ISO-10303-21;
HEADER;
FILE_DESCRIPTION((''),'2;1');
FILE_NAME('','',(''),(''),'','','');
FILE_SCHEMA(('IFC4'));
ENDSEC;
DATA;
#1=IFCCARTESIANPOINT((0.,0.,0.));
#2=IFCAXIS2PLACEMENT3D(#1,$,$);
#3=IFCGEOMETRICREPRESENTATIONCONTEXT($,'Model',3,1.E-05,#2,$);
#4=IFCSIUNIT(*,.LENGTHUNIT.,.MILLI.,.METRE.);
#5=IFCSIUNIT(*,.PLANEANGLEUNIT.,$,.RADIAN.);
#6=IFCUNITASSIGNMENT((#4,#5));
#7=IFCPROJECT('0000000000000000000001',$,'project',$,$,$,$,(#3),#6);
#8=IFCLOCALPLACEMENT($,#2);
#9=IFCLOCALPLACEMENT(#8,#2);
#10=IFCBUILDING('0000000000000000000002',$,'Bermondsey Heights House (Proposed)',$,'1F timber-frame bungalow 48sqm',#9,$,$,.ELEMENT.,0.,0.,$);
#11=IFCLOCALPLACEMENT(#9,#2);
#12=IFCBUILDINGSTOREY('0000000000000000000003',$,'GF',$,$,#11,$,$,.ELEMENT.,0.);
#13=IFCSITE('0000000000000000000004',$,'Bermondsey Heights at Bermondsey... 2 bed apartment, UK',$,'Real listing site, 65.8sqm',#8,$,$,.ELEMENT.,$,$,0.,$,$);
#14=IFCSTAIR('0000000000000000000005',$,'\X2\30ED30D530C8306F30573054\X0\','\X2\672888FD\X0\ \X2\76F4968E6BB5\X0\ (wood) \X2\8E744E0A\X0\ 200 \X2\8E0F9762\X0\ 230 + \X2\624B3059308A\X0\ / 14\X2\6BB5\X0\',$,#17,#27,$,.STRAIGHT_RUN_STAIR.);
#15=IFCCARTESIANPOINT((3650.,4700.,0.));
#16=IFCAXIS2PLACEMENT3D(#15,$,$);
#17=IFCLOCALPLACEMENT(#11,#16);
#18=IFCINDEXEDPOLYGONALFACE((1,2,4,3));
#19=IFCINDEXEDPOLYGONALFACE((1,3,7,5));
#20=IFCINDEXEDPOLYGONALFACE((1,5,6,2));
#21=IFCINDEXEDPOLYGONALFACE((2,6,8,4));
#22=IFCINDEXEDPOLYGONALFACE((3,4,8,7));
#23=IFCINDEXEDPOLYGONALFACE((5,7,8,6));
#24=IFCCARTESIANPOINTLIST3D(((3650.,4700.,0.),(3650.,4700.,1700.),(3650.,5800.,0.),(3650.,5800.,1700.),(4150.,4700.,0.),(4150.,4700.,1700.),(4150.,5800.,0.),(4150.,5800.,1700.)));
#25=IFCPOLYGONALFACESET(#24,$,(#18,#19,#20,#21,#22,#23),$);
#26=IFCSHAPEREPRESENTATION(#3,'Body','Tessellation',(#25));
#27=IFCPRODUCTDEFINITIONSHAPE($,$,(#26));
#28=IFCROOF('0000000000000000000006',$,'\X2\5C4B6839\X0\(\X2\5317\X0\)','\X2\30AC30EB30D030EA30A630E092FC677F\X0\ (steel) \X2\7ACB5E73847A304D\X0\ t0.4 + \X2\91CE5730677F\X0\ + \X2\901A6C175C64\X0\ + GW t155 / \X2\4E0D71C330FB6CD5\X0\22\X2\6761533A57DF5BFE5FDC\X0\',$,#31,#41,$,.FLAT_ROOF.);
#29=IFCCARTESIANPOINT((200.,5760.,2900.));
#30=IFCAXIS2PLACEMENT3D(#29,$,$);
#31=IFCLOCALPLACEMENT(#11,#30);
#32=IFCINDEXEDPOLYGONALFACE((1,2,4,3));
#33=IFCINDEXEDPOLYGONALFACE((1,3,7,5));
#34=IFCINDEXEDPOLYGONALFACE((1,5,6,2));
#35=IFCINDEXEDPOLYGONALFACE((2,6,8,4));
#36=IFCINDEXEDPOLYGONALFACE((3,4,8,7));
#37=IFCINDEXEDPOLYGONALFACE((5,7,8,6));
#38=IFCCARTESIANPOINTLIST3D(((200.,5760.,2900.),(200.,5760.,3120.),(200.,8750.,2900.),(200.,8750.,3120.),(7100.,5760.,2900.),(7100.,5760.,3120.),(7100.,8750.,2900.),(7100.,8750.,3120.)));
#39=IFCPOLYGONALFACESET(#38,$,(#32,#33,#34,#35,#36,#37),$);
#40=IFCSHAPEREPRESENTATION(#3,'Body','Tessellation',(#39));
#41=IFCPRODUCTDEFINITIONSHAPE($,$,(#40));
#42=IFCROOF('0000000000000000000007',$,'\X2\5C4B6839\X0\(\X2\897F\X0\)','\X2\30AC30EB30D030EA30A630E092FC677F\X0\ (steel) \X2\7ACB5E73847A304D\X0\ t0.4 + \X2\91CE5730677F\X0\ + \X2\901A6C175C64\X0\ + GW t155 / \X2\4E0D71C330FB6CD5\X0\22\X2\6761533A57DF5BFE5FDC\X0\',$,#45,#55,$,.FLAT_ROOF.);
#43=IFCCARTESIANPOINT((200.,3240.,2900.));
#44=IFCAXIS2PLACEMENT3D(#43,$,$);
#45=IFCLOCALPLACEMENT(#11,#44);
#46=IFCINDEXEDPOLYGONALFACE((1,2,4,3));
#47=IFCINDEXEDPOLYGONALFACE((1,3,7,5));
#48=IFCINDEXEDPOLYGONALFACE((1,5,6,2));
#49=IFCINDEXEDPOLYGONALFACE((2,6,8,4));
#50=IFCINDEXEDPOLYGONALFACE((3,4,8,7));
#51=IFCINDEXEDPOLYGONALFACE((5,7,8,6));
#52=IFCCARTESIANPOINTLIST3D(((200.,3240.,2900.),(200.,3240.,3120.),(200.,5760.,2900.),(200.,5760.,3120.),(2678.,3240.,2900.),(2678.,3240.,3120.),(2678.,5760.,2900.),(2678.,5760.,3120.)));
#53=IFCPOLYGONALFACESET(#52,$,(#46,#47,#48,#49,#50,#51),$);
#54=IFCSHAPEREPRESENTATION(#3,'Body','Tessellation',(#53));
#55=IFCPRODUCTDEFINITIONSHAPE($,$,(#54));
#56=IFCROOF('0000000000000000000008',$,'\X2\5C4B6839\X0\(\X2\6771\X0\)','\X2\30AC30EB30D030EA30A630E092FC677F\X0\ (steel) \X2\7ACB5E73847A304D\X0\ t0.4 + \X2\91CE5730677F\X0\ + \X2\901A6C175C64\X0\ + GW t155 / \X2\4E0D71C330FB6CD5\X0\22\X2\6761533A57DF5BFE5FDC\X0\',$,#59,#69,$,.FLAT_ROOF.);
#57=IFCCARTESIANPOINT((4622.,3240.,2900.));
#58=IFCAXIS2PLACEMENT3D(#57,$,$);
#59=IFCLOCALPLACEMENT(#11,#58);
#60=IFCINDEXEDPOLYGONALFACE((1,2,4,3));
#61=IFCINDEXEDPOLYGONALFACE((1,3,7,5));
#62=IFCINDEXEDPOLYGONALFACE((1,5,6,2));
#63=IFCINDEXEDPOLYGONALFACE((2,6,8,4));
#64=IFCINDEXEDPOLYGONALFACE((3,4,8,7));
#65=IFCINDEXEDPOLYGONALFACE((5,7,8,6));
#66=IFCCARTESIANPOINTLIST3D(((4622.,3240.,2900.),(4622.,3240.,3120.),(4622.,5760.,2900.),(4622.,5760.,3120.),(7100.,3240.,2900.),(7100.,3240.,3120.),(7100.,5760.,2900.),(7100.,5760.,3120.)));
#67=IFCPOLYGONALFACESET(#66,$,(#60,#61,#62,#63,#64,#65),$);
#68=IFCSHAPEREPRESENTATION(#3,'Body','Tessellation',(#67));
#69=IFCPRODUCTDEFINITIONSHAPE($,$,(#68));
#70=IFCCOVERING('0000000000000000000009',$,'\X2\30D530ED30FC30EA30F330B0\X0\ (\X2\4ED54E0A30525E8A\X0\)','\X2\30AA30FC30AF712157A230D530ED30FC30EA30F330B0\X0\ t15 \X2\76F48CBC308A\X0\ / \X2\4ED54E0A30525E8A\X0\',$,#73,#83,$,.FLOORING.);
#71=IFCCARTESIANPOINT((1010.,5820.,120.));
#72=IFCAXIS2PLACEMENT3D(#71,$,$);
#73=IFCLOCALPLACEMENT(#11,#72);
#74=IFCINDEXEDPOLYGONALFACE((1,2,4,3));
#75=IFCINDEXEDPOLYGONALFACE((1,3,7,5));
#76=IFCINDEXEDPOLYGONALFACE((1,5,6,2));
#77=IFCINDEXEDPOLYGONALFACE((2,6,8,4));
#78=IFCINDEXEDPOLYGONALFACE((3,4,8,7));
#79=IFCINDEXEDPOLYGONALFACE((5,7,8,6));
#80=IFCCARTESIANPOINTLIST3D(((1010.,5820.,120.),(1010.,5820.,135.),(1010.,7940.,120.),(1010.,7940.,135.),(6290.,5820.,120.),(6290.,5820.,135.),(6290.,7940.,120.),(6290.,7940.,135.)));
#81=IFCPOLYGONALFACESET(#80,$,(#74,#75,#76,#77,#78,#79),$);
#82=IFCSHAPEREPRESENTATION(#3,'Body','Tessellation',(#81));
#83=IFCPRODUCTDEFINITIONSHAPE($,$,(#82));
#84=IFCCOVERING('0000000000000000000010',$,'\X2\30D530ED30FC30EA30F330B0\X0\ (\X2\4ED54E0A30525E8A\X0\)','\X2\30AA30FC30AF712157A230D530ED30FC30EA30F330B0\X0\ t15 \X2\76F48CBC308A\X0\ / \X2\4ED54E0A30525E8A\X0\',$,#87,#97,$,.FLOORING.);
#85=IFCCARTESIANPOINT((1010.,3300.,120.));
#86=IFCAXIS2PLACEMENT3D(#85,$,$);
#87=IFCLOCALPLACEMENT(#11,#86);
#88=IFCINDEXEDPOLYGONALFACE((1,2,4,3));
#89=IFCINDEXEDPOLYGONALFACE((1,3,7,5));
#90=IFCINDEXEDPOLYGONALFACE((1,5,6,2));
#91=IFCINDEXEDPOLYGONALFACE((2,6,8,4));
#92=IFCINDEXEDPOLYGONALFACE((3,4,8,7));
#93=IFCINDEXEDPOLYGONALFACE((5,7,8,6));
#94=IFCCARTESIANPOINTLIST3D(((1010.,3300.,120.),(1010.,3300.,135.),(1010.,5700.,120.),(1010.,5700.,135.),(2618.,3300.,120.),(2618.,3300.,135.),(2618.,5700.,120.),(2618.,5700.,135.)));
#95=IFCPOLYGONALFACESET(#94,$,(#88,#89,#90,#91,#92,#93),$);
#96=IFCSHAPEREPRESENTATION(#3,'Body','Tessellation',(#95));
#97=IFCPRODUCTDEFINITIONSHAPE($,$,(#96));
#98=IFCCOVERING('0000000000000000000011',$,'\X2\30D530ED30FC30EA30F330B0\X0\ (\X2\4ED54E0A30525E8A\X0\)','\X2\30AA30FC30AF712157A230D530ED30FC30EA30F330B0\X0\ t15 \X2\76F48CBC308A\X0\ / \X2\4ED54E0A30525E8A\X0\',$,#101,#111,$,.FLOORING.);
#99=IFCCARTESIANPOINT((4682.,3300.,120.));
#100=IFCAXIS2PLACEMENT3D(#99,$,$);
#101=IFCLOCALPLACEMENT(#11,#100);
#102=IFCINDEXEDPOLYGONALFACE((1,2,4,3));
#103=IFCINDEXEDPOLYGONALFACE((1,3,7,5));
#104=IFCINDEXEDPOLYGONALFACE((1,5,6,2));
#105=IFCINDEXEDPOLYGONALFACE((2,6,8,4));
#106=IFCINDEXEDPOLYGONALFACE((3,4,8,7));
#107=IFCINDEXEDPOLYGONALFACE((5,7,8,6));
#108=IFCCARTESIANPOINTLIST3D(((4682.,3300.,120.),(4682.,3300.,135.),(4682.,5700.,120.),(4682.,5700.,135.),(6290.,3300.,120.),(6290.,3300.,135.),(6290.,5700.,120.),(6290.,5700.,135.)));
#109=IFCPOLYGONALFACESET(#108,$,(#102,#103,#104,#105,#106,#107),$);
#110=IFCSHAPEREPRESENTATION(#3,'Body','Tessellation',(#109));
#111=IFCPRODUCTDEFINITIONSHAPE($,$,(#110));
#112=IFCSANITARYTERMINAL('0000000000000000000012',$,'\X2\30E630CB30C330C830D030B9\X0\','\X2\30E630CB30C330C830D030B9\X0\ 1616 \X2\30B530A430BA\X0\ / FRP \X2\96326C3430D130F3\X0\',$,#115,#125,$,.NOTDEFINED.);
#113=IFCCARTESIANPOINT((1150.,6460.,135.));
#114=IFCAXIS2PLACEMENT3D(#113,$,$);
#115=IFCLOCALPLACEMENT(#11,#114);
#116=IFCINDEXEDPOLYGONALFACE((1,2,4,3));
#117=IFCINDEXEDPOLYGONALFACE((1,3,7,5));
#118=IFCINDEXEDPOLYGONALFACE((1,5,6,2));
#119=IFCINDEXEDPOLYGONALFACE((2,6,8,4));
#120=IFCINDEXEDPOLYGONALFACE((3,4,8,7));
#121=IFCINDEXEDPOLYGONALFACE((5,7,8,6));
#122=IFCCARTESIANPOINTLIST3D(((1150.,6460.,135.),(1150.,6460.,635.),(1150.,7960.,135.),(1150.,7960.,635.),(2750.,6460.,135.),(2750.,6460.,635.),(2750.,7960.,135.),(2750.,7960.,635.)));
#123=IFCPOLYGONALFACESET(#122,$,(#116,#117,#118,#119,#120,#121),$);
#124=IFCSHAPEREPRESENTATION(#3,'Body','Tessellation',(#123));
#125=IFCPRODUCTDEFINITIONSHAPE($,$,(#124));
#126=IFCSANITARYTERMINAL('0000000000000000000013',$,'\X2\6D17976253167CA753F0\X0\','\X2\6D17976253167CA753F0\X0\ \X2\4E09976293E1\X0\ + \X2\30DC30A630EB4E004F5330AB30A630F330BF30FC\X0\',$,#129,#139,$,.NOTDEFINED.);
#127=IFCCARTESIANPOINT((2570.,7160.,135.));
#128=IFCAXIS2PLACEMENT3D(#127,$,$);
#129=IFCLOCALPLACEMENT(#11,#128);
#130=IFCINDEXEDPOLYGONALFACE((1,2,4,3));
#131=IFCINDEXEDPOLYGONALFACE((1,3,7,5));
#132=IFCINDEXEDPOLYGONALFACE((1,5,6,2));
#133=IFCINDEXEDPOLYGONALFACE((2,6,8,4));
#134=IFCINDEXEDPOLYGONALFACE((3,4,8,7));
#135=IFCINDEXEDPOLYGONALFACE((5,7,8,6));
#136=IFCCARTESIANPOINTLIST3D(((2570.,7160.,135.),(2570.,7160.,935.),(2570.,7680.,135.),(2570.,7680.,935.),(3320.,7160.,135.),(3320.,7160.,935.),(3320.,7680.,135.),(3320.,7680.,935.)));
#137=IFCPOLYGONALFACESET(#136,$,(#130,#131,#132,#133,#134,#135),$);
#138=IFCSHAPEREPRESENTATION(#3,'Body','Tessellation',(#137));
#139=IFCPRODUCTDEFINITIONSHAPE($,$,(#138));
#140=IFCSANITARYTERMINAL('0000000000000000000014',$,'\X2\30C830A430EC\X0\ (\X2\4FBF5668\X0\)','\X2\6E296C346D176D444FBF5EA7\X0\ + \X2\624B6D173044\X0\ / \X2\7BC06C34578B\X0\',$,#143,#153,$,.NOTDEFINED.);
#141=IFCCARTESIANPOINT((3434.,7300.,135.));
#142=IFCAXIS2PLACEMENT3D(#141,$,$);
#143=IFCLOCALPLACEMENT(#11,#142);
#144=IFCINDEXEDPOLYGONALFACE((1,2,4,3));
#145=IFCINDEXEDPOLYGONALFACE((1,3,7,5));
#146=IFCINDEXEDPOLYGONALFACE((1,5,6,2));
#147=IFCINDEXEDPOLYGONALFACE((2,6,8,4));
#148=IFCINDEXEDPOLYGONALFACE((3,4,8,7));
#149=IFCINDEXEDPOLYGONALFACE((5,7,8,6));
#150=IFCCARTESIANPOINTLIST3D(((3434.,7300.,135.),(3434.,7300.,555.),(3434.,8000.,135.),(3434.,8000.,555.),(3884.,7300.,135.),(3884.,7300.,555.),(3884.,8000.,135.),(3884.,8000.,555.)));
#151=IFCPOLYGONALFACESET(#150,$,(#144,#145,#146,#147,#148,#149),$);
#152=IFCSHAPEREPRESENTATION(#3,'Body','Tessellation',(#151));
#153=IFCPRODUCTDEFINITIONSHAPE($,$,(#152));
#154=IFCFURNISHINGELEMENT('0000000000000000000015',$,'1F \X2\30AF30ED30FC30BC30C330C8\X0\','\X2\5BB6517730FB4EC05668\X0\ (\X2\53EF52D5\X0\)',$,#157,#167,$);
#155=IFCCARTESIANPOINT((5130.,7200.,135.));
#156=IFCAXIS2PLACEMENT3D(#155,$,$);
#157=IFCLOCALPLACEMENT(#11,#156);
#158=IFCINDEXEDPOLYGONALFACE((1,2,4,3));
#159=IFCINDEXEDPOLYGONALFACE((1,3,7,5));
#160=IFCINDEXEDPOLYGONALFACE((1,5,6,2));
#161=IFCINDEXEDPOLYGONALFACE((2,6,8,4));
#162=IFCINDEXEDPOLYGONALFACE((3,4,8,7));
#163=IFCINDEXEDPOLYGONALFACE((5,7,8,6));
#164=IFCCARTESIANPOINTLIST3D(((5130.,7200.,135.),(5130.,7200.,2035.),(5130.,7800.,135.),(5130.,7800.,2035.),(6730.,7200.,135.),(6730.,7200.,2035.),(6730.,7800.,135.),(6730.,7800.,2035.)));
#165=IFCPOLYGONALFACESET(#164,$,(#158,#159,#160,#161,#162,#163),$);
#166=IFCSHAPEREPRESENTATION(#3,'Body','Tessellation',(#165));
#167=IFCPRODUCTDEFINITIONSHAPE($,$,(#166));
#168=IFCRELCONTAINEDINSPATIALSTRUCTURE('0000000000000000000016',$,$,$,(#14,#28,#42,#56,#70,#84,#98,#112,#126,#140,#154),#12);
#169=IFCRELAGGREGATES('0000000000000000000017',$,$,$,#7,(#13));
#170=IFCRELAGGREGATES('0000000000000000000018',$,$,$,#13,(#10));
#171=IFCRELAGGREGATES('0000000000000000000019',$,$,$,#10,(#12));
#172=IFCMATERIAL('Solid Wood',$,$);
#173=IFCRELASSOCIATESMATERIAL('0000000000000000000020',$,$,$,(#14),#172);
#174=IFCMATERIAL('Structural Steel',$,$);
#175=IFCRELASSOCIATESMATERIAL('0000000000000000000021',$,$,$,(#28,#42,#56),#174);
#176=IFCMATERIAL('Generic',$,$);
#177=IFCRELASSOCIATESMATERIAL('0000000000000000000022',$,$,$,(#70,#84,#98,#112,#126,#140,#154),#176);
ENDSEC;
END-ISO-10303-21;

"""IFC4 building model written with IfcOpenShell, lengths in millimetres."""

from ifc_helpers import new_model, si_unit, frame, frame_2d, origin, place, context, project, spatial, rectangle, extrude, material, element, save


model = new_model("IFC4")

# Units and contexts
model_context = context("Model", 3, precision=1e-05, world=origin())
ifc_project = project(units=[si_unit("LENGTHUNIT", "METRE", prefix="MILLI"), si_unit("PLANEANGLEUNIT", "RADIAN")], contexts=[model_context])

# Site, building, storey
site_placement = place(None, origin())
site = spatial("IfcSite", under=ifc_project, at=site_placement, Name="Bermondsey Heights at Bermondsey... 2 bed apartment, UK", ObjectType="Real listing site, 65.8sqm", CompositionType="ELEMENT", RefElevation=0.0)
building_placement = place(site_placement, origin())
building = spatial("IfcBuilding", under=site, at=building_placement, Name="Bermondsey Heights House (Proposed)", ObjectType="1F timber-frame bungalow 48sqm", CompositionType="ELEMENT", ElevationOfRefHeight=0.0, ElevationOfTerrain=0.0)
storey_placement = place(building_placement, origin())
storey = spatial("IfcBuildingStorey", under=building, at=storey_placement, Name="GF", CompositionType="ELEMENT", Elevation=0.0)

# Shared definitions
ifc_material_1 = material(Name="Solid Wood")

# Shared definitions
ifc_material_2 = material(Name="Generic")

# Stair
stair_placement = place(storey_placement, frame((3650.0, 4700.0, 0.0)))
element("IfcStair", 1, at=stair_placement, inside=storey, material=ifc_material_1, Name="ロフトはしご", Description="木製 直階段 (wood) 蹴上 200 踏面 230 + 手すり / 14段", PredefinedType="STRAIGHT_RUN_STAIR", context=model_context, shape_type="SweptSolid", body=[
    extrude(rectangle(XDim=500.0, YDim=1100.0, at=frame_2d((250.0, 550.0))), frame((3650.0, 4700.0, 0.0)), (0.0, 0.0, 1.0), 1700.0),
])

# Roofs
ifc_material_3 = material(Name="Structural Steel")
roof_1_placement = place(storey_placement, frame((200.0, 5760.0, 2900.0)))
element("IfcRoof", 2, at=roof_1_placement, inside=storey, material=ifc_material_3, Name="屋根(北)", Description="ガルバリウム鋼板 (steel) 立平葺き t0.4 + 野地板 + 通気層 + GW t155 / 不燃・法22条区域対応", PredefinedType="FLAT_ROOF", context=model_context, shape_type="SweptSolid", body=[
    extrude(rectangle(XDim=6900.0, YDim=2990.0, at=frame_2d((3450.0, 1495.0))), frame((200.0, 5760.0, 2900.0)), (0.0, 0.0, 1.0), 220.0),
])
roof_2_placement = place(storey_placement, frame((200.0, 3240.0, 2900.0)))
element("IfcRoof", 3, at=roof_2_placement, inside=storey, material=ifc_material_3, Name="屋根(西)", Description="ガルバリウム鋼板 (steel) 立平葺き t0.4 + 野地板 + 通気層 + GW t155 / 不燃・法22条区域対応", PredefinedType="FLAT_ROOF", context=model_context, shape_type="SweptSolid", body=[
    extrude(rectangle(XDim=2478.0, YDim=2520.0, at=frame_2d((1239.0, 1260.0))), frame((200.0, 3240.0, 2900.0)), (0.0, 0.0, 1.0), 220.0),
])
roof_3_placement = place(storey_placement, frame((4622.0, 3240.0, 2900.0)))
element("IfcRoof", 4, at=roof_3_placement, inside=storey, material=ifc_material_3, Name="屋根(東)", Description="ガルバリウム鋼板 (steel) 立平葺き t0.4 + 野地板 + 通気層 + GW t155 / 不燃・法22条区域対応", PredefinedType="FLAT_ROOF", context=model_context, shape_type="SweptSolid", body=[
    extrude(rectangle(XDim=2478.0, YDim=2520.0, at=frame_2d((1239.0, 1260.0))), frame((4622.0, 3240.0, 2900.0)), (0.0, 0.0, 1.0), 220.0),
])

# Coverings
covering_1_placement = place(storey_placement, frame((1010.0, 5820.0, 120.0)))
element("IfcCovering", 5, at=covering_1_placement, inside=storey, material=ifc_material_2, Name="フローリング (仕上げ床)", Description="オーク無垢フローリング t15 直貼り / 仕上げ床", PredefinedType="FLOORING", context=model_context, shape_type="SweptSolid", body=[
    extrude(rectangle(XDim=5280.0, YDim=2120.0, at=frame_2d((2640.0, 1060.0))), frame((1010.0, 5820.0, 120.0)), (0.0, 0.0, 1.0), 15.0),
])
covering_2_placement = place(storey_placement, frame((1010.0, 3300.0, 120.0)))
element("IfcCovering", 6, at=covering_2_placement, inside=storey, material=ifc_material_2, Name="フローリング (仕上げ床)", Description="オーク無垢フローリング t15 直貼り / 仕上げ床", PredefinedType="FLOORING", context=model_context, shape_type="SweptSolid", body=[
    extrude(rectangle(XDim=1608.0, YDim=2400.0, at=frame_2d((804.0, 1200.0))), frame((1010.0, 3300.0, 120.0)), (0.0, 0.0, 1.0), 15.0),
])
covering_3_placement = place(storey_placement, frame((4682.0, 3300.0, 120.0)))
element("IfcCovering", 7, at=covering_3_placement, inside=storey, material=ifc_material_2, Name="フローリング (仕上げ床)", Description="オーク無垢フローリング t15 直貼り / 仕上げ床", PredefinedType="FLOORING", context=model_context, shape_type="SweptSolid", body=[
    extrude(rectangle(XDim=1608.0, YDim=2400.0, at=frame_2d((804.0, 1200.0))), frame((4682.0, 3300.0, 120.0)), (0.0, 0.0, 1.0), 15.0),
])

# Sanitary terminals
sanitary_terminal_1_placement = place(storey_placement, frame((1150.0, 6460.0, 135.0)))
element("IfcSanitaryTerminal", 8, at=sanitary_terminal_1_placement, inside=storey, material=ifc_material_2, Name="ユニットバス", Description="ユニットバス 1616 サイズ / FRP 防水パン", PredefinedType="NOTDEFINED", context=model_context, shape_type="SweptSolid", body=[
    extrude(rectangle(XDim=1600.0, YDim=1500.0, at=frame_2d((800.0, 750.0))), frame((1150.0, 6460.0, 135.0)), (0.0, 0.0, 1.0), 500.0),
])
sanitary_terminal_2_placement = place(storey_placement, frame((2570.0, 7160.0, 135.0)))
element("IfcSanitaryTerminal", 9, at=sanitary_terminal_2_placement, inside=storey, material=ifc_material_2, Name="洗面化粧台", Description="洗面化粧台 三面鏡 + ボウル一体カウンター", PredefinedType="NOTDEFINED", context=model_context, shape_type="SweptSolid", body=[
    extrude(rectangle(XDim=750.0, YDim=520.0, at=frame_2d((375.0, 260.0))), frame((2570.0, 7160.0, 135.0)), (0.0, 0.0, 1.0), 800.0),
])
sanitary_terminal_3_placement = place(storey_placement, frame((3434.0, 7300.0, 135.0)))
element("IfcSanitaryTerminal", 10, at=sanitary_terminal_3_placement, inside=storey, material=ifc_material_2, Name="トイレ (便器)", Description="温水洗浄便座 + 手洗い / 節水型", PredefinedType="NOTDEFINED", context=model_context, shape_type="SweptSolid", body=[
    extrude(rectangle(XDim=450.0, YDim=700.0, at=frame_2d((225.0, 350.0))), frame((3434.0, 7300.0, 135.0)), (0.0, 0.0, 1.0), 420.0),
])

# Furnishing element
furnishing_placement = place(storey_placement, frame((5130.0, 7200.0, 135.0)))
element("IfcFurnishingElement", 11, at=furnishing_placement, inside=storey, material=ifc_material_2, Name="1F クローゼット", Description="家具・什器 (可動)", context=model_context, shape_type="SweptSolid", body=[
    extrude(rectangle(XDim=1600.0, YDim=600.0, at=frame_2d((800.0, 300.0))), frame((5130.0, 7200.0, 135.0)), (0.0, 0.0, 1.0), 1900.0),
])

save(model, "model.ifc")
